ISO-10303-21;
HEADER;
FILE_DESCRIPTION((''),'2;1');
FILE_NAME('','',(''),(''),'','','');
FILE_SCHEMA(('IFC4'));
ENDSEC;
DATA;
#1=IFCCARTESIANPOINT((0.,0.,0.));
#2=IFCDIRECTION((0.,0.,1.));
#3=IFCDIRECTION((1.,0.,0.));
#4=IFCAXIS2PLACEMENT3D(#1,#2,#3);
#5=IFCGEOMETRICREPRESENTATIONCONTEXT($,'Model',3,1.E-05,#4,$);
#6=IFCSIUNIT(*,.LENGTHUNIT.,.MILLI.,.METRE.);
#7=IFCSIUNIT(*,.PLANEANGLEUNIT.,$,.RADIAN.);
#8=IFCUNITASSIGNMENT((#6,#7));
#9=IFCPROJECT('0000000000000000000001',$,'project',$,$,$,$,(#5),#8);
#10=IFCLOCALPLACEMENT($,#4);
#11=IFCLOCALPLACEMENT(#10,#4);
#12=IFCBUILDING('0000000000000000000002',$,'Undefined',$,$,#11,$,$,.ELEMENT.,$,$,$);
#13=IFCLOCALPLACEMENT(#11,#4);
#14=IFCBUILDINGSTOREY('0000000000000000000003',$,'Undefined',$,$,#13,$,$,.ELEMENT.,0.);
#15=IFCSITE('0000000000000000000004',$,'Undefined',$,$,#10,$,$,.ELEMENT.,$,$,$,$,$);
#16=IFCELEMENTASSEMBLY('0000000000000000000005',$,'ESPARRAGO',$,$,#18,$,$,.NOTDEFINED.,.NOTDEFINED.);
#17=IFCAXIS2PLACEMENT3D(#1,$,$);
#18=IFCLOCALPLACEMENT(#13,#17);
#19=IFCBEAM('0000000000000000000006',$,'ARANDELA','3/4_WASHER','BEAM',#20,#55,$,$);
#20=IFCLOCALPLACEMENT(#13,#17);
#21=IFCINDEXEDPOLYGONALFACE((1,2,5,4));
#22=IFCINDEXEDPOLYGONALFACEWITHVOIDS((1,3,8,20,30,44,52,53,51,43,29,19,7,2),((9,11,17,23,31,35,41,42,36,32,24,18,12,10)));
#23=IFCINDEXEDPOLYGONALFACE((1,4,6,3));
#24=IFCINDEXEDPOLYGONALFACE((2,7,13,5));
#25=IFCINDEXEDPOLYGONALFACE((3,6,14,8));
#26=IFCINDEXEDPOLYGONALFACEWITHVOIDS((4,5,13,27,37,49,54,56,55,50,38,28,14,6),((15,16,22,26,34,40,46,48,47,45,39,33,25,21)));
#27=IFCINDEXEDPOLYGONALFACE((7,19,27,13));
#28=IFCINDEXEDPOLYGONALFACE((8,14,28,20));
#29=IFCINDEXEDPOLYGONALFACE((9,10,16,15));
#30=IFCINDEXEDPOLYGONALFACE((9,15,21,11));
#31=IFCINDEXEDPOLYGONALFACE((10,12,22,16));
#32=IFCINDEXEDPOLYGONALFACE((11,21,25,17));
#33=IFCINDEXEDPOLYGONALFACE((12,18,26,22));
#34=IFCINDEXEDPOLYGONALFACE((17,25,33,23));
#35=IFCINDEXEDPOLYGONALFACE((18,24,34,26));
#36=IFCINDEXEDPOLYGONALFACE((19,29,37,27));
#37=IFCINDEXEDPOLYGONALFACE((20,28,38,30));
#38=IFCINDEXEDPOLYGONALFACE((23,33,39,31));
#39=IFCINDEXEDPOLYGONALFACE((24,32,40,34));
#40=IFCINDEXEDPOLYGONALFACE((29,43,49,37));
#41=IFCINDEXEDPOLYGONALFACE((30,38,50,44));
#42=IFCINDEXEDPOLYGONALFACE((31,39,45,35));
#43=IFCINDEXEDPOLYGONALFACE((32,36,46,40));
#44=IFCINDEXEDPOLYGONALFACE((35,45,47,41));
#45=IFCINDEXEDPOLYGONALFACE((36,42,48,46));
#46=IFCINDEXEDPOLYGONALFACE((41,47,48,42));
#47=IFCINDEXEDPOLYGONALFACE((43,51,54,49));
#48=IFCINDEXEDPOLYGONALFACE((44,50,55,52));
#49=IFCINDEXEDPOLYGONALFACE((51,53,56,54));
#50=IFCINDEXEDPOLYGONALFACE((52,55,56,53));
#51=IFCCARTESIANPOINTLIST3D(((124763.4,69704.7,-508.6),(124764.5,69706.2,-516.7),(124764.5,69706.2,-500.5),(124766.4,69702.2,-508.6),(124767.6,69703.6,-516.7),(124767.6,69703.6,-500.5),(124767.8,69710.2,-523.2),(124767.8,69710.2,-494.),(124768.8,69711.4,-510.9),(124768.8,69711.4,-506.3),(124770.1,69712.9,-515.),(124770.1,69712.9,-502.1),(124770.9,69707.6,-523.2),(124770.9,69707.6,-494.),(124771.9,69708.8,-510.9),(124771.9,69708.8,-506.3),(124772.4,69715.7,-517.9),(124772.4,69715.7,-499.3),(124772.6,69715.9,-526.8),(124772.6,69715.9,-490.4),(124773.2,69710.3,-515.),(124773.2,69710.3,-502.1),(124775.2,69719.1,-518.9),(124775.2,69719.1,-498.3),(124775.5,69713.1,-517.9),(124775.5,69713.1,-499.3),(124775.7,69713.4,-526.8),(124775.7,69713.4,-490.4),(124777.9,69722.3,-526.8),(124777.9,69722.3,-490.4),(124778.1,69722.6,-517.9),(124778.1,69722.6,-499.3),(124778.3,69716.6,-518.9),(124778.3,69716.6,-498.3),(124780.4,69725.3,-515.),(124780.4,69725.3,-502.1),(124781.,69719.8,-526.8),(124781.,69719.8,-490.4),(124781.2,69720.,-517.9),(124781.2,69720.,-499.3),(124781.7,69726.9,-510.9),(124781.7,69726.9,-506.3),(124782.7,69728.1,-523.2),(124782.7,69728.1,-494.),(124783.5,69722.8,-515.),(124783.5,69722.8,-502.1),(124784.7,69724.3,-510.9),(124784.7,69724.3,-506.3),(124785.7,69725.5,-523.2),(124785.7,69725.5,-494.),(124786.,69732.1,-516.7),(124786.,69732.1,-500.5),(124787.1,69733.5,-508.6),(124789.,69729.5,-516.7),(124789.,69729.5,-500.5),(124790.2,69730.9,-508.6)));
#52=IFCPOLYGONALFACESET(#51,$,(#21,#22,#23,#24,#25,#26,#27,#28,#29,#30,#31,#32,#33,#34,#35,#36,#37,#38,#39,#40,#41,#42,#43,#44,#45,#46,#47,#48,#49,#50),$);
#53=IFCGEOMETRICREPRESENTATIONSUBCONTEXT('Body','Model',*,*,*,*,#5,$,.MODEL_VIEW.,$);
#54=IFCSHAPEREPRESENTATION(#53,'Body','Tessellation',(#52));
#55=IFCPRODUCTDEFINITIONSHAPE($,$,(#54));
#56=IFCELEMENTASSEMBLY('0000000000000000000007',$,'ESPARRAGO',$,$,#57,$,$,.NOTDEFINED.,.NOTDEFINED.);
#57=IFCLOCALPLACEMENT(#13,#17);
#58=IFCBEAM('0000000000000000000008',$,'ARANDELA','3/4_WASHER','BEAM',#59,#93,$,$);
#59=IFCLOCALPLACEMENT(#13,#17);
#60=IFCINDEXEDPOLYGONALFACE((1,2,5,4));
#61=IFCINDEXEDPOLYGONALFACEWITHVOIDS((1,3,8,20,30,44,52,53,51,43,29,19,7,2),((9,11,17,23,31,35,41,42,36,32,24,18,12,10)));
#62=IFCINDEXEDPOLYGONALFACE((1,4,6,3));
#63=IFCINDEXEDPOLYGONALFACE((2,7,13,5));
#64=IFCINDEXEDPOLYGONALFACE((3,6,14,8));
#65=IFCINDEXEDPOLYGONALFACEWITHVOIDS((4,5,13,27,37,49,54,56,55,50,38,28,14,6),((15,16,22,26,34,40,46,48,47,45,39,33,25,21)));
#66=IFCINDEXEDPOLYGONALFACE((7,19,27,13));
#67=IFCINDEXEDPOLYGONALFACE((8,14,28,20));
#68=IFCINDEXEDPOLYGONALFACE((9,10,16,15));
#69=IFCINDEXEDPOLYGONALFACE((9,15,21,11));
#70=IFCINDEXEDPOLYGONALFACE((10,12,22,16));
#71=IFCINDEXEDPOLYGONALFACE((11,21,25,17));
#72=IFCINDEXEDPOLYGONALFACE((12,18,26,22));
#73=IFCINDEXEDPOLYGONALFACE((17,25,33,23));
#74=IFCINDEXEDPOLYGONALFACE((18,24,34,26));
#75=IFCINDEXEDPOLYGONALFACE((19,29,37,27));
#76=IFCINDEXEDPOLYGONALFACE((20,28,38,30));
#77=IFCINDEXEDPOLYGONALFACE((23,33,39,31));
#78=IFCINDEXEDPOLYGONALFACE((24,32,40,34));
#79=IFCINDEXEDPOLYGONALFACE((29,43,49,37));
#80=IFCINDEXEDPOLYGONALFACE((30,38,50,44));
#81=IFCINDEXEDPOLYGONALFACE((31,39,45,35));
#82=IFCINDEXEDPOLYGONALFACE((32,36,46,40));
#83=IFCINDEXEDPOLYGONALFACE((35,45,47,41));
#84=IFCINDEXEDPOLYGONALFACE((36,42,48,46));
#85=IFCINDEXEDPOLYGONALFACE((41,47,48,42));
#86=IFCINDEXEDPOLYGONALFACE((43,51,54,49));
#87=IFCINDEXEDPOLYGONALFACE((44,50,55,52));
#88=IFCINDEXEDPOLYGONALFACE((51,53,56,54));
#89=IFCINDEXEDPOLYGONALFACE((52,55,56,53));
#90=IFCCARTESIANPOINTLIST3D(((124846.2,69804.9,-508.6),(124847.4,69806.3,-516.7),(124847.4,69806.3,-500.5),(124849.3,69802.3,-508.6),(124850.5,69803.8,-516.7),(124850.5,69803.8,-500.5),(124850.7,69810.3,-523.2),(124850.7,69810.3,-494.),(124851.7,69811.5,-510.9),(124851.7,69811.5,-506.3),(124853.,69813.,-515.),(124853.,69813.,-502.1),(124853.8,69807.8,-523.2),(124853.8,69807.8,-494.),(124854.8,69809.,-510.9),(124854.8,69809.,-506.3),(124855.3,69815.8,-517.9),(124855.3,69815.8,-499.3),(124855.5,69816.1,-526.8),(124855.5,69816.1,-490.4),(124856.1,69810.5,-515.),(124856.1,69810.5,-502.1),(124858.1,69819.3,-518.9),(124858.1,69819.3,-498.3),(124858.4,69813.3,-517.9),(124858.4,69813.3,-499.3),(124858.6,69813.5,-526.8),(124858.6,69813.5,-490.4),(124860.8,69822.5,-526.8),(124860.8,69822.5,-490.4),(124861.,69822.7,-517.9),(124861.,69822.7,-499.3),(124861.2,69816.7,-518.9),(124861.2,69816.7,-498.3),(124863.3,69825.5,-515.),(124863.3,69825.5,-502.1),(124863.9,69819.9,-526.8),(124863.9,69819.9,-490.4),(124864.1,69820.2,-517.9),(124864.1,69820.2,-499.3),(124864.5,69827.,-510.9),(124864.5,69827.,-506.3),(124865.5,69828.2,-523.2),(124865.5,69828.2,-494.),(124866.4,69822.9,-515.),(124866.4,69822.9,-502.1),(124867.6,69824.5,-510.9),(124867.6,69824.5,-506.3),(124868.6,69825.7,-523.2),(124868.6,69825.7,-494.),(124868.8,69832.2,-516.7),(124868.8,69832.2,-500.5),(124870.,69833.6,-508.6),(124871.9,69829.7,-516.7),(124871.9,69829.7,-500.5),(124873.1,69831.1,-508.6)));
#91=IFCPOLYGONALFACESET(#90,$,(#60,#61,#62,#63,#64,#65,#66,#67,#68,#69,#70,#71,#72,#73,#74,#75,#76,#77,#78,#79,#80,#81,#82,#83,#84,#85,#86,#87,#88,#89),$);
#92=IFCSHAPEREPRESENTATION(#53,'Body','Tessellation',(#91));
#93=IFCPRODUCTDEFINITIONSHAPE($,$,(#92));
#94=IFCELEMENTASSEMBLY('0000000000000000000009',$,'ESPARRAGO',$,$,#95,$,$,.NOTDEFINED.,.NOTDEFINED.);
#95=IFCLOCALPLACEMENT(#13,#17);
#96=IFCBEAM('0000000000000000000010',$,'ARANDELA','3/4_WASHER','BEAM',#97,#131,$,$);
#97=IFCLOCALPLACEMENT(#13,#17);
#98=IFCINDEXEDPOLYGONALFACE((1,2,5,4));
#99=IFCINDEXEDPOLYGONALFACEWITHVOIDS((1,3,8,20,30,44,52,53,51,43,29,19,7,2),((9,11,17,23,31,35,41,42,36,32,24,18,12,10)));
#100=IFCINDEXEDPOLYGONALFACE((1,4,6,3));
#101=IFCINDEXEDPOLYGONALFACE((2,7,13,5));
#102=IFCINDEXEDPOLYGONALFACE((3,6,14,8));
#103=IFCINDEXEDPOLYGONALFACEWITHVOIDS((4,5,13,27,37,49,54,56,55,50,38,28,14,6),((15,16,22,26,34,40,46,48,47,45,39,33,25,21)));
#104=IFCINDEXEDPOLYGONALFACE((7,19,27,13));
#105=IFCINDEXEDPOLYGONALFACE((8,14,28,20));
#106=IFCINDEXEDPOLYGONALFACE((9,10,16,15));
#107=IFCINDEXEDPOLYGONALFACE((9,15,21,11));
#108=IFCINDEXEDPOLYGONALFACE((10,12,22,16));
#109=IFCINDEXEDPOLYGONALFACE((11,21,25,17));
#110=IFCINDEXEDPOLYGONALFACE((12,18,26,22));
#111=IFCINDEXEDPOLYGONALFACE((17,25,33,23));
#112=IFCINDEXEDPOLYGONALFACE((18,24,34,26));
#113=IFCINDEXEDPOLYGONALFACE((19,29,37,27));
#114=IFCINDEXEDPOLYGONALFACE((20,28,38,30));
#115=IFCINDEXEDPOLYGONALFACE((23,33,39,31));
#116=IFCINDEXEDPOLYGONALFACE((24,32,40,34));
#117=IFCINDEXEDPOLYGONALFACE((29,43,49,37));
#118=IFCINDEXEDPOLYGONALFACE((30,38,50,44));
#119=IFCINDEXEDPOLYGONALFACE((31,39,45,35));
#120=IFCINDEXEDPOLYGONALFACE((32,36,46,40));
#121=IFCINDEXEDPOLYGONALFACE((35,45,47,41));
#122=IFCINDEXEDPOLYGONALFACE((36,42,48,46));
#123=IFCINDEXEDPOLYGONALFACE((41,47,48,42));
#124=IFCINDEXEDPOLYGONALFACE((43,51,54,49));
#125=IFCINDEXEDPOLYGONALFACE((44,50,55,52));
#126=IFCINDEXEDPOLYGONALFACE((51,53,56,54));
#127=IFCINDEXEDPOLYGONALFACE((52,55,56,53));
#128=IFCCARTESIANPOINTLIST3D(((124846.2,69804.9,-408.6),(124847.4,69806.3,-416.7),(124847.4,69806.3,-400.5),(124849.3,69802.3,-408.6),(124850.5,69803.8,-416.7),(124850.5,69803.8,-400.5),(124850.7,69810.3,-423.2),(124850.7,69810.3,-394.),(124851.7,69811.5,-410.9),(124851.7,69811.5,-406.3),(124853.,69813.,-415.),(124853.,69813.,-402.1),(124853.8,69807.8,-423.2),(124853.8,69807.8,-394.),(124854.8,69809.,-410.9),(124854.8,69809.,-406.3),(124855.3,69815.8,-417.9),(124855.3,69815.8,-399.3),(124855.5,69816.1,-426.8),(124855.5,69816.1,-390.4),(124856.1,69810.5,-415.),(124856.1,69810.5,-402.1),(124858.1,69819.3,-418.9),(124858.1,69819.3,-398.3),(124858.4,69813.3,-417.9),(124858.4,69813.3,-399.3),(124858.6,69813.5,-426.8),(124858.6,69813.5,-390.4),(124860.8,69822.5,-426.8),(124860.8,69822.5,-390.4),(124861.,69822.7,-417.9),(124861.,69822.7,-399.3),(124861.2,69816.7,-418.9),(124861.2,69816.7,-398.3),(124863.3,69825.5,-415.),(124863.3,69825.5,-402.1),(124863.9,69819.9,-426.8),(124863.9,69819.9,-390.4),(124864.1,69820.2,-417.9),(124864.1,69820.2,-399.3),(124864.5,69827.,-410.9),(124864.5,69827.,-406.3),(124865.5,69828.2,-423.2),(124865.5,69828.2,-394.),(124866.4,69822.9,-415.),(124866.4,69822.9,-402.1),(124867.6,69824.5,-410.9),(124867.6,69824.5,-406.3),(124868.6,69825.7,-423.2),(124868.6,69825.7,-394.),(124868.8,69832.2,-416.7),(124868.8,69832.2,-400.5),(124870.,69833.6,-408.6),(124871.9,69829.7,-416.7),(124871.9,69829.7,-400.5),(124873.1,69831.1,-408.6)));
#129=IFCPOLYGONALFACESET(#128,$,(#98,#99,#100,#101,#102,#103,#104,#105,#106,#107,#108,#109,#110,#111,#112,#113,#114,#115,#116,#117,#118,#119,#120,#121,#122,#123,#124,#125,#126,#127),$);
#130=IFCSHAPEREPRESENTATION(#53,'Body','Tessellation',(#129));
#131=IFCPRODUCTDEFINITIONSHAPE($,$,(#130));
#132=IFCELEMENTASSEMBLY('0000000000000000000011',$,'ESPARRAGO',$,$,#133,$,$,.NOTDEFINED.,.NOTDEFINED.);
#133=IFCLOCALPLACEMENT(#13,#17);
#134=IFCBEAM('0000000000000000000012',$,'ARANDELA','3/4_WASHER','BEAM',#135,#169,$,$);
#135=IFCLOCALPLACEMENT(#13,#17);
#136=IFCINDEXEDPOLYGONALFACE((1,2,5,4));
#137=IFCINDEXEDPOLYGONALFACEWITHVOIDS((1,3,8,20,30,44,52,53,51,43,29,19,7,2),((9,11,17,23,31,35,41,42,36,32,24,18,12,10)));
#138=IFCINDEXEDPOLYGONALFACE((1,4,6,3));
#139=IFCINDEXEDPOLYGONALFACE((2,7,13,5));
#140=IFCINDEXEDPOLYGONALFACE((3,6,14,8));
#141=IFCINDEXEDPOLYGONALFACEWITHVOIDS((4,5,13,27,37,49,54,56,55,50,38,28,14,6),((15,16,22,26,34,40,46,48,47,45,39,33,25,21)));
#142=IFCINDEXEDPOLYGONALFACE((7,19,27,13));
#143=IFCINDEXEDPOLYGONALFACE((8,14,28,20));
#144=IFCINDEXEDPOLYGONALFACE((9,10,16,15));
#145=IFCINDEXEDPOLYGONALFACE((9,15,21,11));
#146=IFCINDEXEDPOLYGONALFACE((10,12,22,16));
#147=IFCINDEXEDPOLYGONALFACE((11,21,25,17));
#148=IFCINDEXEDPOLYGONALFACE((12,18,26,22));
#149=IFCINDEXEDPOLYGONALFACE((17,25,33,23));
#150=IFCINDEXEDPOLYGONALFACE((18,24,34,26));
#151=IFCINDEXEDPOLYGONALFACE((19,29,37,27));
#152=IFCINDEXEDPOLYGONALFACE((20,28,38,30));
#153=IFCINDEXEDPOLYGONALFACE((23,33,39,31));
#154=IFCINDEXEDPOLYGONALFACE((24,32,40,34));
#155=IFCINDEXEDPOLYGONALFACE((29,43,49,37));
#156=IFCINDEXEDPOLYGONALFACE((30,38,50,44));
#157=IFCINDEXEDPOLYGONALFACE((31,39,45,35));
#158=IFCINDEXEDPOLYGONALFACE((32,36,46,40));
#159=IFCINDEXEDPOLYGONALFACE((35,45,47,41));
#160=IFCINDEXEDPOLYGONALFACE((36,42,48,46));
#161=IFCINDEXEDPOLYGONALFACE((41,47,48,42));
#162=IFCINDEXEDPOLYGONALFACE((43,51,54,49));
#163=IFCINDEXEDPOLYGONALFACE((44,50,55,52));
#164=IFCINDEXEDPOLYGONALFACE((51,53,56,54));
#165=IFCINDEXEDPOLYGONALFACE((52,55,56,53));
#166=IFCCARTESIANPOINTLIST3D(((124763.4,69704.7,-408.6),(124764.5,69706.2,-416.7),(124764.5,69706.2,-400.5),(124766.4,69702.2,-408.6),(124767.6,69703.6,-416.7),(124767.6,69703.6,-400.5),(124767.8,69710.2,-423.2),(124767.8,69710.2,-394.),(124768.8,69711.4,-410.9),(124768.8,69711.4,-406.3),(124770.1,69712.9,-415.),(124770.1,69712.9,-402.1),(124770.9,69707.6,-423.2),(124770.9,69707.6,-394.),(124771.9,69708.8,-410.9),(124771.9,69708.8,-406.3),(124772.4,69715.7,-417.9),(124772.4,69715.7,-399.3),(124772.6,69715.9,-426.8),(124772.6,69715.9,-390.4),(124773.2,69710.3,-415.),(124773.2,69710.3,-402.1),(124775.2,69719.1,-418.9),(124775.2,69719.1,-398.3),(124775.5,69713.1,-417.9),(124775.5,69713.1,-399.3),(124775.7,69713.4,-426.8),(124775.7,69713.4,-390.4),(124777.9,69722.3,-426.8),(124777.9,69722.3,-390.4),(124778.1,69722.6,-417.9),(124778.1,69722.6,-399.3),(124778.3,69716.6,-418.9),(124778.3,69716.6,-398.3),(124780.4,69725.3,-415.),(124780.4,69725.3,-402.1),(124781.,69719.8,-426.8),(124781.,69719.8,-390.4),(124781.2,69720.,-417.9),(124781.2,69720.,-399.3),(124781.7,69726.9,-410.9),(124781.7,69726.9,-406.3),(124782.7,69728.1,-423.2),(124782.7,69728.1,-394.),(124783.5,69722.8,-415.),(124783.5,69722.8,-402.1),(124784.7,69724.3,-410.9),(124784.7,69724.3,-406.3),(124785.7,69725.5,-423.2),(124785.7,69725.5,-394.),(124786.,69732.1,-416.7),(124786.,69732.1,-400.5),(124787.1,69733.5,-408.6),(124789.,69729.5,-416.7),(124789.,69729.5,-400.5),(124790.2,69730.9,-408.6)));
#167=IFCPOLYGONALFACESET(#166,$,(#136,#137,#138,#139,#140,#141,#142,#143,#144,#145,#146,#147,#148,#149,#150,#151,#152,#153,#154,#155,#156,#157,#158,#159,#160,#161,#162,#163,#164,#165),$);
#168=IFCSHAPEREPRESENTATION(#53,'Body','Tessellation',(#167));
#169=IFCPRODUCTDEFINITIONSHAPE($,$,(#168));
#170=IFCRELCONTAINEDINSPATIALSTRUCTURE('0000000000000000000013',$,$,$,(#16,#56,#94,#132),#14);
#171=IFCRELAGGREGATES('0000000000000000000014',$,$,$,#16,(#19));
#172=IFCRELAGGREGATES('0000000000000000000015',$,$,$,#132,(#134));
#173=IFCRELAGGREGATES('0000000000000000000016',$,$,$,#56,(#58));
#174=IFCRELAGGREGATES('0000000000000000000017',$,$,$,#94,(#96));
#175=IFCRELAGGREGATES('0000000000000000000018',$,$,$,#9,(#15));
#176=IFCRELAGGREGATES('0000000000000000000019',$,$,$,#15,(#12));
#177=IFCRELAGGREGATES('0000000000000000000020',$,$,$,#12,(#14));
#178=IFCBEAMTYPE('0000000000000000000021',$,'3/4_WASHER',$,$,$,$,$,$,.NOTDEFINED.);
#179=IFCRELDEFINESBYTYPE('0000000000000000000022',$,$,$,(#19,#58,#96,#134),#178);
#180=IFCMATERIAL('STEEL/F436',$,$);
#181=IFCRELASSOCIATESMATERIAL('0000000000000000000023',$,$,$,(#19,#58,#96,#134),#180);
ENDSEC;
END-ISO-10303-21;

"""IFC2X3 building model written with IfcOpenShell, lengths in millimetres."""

from ifc_helpers import new_model, si_unit, frame, origin_with_axes, place, context, subcontext, project, spatial, polyline, outline, extrude, material, type_object, element, aggregate, save


model = new_model("IFC2X3")

# Units and contexts
model_context = context("Model", 3, precision=1e-05, world=origin_with_axes())
body_context = subcontext(model_context, "Body", "Model", "MODEL_VIEW")
ifc_project = project(units=[si_unit("LENGTHUNIT", "METRE", prefix="MILLI"), si_unit("PLANEANGLEUNIT", "RADIAN")], contexts=[model_context])

# Site, building, storey
site_placement = place(None, origin_with_axes())
site = spatial("IfcSite", under=ifc_project, at=site_placement, Name="Undefined", CompositionType="ELEMENT")
building_placement = place(site_placement, origin_with_axes())
building = spatial("IfcBuilding", under=site, at=building_placement, Name="Undefined", CompositionType="ELEMENT")
storey_placement = place(building_placement, origin_with_axes())
storey = spatial("IfcBuildingStorey", under=building, at=storey_placement, Name="Undefined", CompositionType="ELEMENT", Elevation=0.0)

# Element assemblies, beams
ifc_material_1 = material(Name="STEEL/F436")
beam_type_1 = type_object("IfcBeamType", Name="3/4_WASHER", PredefinedType="NOTDEFINED")
assembly_1_placement = place(storey_placement, origin_with_axes())
assembly_1 = element("IfcElementAssembly", 1, at=assembly_1_placement, inside=storey, Name="ESPARRAGO", AssemblyPlace="NOTDEFINED", PredefinedType="NOTDEFINED")
beam_1_placement = place(assembly_1_placement, frame((124775.2, 69719.1, -508.6), z_axis=(0.000066, -0.000055, 1.0), x_axis=(0.7704, -0.637561, -0.000086)))
beam_1 = element("IfcBeam", 2, at=beam_1_placement, type_object=beam_type_1, material=ifc_material_1, Name="ARANDELA", Description="3/4_WASHER", ObjectType="BEAM", context=body_context, shape_type="SweptSolid", body=[
    extrude(outline(polyline([(-11.6, -14.6), (-16.8, -8.1), (-18.6, 0.0), (-16.8, 8.1), (-11.6, 14.6), (-4.2, 18.2), (4.2, 18.2), (11.6, 14.6), (16.8, 8.1), (18.6, 0.0), (16.8, -8.1), (11.6, -14.6), (4.2, -18.2), (-4.2, -18.2), (-11.6, -14.6)]), holes=[polyline([(-4.5, 9.3), (-8.1, 6.4), (-10.1, 2.3), (-10.1, -2.3), (-8.1, -6.4), (-4.5, -9.3), (0.0, -10.3), (4.5, -9.3), (8.1, -6.4), (10.1, -2.3), (10.1, 2.3), (8.1, 6.4), (4.5, 9.3), (0.0, 10.3), (-4.5, 9.3)])]), frame((4.0, 0.0, 0.0), z_axis=(-1.0, 0.0, 0.0), x_axis=(0.0, -1.0, 0.0)), (0.0, 0.0, 1.0), 4.0),
])
aggregate(assembly_1, [beam_1])
assembly_2_placement = place(storey_placement, origin_with_axes())
assembly_2 = element("IfcElementAssembly", 3, at=assembly_2_placement, inside=storey, Name="ESPARRAGO", AssemblyPlace="NOTDEFINED", PredefinedType="NOTDEFINED")
beam_2_placement = place(assembly_2_placement, frame((124858.1, 69819.3, -508.6), z_axis=(0.000066, -0.000055, 1.0), x_axis=(0.7704, -0.637561, -0.000086)))
beam_2 = element("IfcBeam", 4, at=beam_2_placement, type_object=beam_type_1, material=ifc_material_1, Name="ARANDELA", Description="3/4_WASHER", ObjectType="BEAM", context=body_context, shape_type="SweptSolid", body=[
    extrude(outline(polyline([(-11.6, -14.6), (-16.8, -8.1), (-18.6, 0.0), (-16.8, 8.1), (-11.6, 14.6), (-4.2, 18.2), (4.2, 18.2), (11.6, 14.6), (16.8, 8.1), (18.6, 0.0), (16.8, -8.1), (11.6, -14.6), (4.2, -18.2), (-4.2, -18.2), (-11.6, -14.6)]), holes=[polyline([(-4.5, 9.3), (-8.1, 6.4), (-10.1, 2.3), (-10.1, -2.3), (-8.1, -6.4), (-4.5, -9.3), (0.0, -10.3), (4.5, -9.3), (8.1, -6.4), (10.1, -2.3), (10.1, 2.3), (8.1, 6.4), (4.5, 9.3), (0.0, 10.3), (-4.5, 9.3)])]), frame((4.0, 0.0, 0.0), z_axis=(-1.0, 0.0, 0.0), x_axis=(0.0, -1.0, 0.0)), (0.0, 0.0, 1.0), 4.0),
])
assembly_3_placement = place(storey_placement, origin_with_axes())
assembly_3 = element("IfcElementAssembly", 5, at=assembly_3_placement, inside=storey, Name="ESPARRAGO", AssemblyPlace="NOTDEFINED", PredefinedType="NOTDEFINED")
beam_3_placement = place(assembly_3_placement, frame((124858.1, 69819.3, -408.6), z_axis=(0.000066, -0.000055, 1.0), x_axis=(0.7704, -0.637561, -0.000086)))
beam_3 = element("IfcBeam", 6, at=beam_3_placement, type_object=beam_type_1, material=ifc_material_1, Name="ARANDELA", Description="3/4_WASHER", ObjectType="BEAM", context=body_context, shape_type="SweptSolid", body=[
    extrude(outline(polyline([(-11.6, -14.6), (-16.8, -8.1), (-18.6, 0.0), (-16.8, 8.1), (-11.6, 14.6), (-4.2, 18.2), (4.2, 18.2), (11.6, 14.6), (16.8, 8.1), (18.6, 0.0), (16.8, -8.1), (11.6, -14.6), (4.2, -18.2), (-4.2, -18.2), (-11.6, -14.6)]), holes=[polyline([(-4.5, 9.3), (-8.1, 6.4), (-10.1, 2.3), (-10.1, -2.3), (-8.1, -6.4), (-4.5, -9.3), (0.0, -10.3), (4.5, -9.3), (8.1, -6.4), (10.1, -2.3), (10.1, 2.3), (8.1, 6.4), (4.5, 9.3), (0.0, 10.3), (-4.5, 9.3)])]), frame((4.0, 0.0, 0.0), z_axis=(-1.0, 0.0, 0.0), x_axis=(0.0, -1.0, 0.0)), (0.0, 0.0, 1.0), 4.0),
])
assembly_4_placement = place(storey_placement, origin_with_axes())
assembly_4 = element("IfcElementAssembly", 7, at=assembly_4_placement, inside=storey, Name="ESPARRAGO", AssemblyPlace="NOTDEFINED", PredefinedType="NOTDEFINED")
beam_4_placement = place(assembly_4_placement, frame((124775.2, 69719.1, -408.6), z_axis=(0.000066, -0.000055, 1.0), x_axis=(0.7704, -0.637561, -0.000086)))
beam_4 = element("IfcBeam", 8, at=beam_4_placement, type_object=beam_type_1, material=ifc_material_1, Name="ARANDELA", Description="3/4_WASHER", ObjectType="BEAM", context=body_context, shape_type="SweptSolid", body=[
    extrude(outline(polyline([(-11.6, -14.6), (-16.8, -8.1), (-18.6, 0.0), (-16.8, 8.1), (-11.6, 14.6), (-4.2, 18.2), (4.2, 18.2), (11.6, 14.6), (16.8, 8.1), (18.6, 0.0), (16.8, -8.1), (11.6, -14.6), (4.2, -18.2), (-4.2, -18.2), (-11.6, -14.6)]), holes=[polyline([(-4.5, 9.3), (-8.1, 6.4), (-10.1, 2.3), (-10.1, -2.3), (-8.1, -6.4), (-4.5, -9.3), (0.0, -10.3), (4.5, -9.3), (8.1, -6.4), (10.1, -2.3), (10.1, 2.3), (8.1, 6.4), (4.5, 9.3), (0.0, 10.3), (-4.5, 9.3)])]), frame((4.0, 0.0, 0.0), z_axis=(-1.0, 0.0, 0.0), x_axis=(0.0, -1.0, 0.0)), (0.0, 0.0, 1.0), 4.0),
])
aggregate(assembly_4, [beam_4])

aggregate(assembly_2, [beam_2])
aggregate(assembly_3, [beam_3])

save(model, "model.ifc")
